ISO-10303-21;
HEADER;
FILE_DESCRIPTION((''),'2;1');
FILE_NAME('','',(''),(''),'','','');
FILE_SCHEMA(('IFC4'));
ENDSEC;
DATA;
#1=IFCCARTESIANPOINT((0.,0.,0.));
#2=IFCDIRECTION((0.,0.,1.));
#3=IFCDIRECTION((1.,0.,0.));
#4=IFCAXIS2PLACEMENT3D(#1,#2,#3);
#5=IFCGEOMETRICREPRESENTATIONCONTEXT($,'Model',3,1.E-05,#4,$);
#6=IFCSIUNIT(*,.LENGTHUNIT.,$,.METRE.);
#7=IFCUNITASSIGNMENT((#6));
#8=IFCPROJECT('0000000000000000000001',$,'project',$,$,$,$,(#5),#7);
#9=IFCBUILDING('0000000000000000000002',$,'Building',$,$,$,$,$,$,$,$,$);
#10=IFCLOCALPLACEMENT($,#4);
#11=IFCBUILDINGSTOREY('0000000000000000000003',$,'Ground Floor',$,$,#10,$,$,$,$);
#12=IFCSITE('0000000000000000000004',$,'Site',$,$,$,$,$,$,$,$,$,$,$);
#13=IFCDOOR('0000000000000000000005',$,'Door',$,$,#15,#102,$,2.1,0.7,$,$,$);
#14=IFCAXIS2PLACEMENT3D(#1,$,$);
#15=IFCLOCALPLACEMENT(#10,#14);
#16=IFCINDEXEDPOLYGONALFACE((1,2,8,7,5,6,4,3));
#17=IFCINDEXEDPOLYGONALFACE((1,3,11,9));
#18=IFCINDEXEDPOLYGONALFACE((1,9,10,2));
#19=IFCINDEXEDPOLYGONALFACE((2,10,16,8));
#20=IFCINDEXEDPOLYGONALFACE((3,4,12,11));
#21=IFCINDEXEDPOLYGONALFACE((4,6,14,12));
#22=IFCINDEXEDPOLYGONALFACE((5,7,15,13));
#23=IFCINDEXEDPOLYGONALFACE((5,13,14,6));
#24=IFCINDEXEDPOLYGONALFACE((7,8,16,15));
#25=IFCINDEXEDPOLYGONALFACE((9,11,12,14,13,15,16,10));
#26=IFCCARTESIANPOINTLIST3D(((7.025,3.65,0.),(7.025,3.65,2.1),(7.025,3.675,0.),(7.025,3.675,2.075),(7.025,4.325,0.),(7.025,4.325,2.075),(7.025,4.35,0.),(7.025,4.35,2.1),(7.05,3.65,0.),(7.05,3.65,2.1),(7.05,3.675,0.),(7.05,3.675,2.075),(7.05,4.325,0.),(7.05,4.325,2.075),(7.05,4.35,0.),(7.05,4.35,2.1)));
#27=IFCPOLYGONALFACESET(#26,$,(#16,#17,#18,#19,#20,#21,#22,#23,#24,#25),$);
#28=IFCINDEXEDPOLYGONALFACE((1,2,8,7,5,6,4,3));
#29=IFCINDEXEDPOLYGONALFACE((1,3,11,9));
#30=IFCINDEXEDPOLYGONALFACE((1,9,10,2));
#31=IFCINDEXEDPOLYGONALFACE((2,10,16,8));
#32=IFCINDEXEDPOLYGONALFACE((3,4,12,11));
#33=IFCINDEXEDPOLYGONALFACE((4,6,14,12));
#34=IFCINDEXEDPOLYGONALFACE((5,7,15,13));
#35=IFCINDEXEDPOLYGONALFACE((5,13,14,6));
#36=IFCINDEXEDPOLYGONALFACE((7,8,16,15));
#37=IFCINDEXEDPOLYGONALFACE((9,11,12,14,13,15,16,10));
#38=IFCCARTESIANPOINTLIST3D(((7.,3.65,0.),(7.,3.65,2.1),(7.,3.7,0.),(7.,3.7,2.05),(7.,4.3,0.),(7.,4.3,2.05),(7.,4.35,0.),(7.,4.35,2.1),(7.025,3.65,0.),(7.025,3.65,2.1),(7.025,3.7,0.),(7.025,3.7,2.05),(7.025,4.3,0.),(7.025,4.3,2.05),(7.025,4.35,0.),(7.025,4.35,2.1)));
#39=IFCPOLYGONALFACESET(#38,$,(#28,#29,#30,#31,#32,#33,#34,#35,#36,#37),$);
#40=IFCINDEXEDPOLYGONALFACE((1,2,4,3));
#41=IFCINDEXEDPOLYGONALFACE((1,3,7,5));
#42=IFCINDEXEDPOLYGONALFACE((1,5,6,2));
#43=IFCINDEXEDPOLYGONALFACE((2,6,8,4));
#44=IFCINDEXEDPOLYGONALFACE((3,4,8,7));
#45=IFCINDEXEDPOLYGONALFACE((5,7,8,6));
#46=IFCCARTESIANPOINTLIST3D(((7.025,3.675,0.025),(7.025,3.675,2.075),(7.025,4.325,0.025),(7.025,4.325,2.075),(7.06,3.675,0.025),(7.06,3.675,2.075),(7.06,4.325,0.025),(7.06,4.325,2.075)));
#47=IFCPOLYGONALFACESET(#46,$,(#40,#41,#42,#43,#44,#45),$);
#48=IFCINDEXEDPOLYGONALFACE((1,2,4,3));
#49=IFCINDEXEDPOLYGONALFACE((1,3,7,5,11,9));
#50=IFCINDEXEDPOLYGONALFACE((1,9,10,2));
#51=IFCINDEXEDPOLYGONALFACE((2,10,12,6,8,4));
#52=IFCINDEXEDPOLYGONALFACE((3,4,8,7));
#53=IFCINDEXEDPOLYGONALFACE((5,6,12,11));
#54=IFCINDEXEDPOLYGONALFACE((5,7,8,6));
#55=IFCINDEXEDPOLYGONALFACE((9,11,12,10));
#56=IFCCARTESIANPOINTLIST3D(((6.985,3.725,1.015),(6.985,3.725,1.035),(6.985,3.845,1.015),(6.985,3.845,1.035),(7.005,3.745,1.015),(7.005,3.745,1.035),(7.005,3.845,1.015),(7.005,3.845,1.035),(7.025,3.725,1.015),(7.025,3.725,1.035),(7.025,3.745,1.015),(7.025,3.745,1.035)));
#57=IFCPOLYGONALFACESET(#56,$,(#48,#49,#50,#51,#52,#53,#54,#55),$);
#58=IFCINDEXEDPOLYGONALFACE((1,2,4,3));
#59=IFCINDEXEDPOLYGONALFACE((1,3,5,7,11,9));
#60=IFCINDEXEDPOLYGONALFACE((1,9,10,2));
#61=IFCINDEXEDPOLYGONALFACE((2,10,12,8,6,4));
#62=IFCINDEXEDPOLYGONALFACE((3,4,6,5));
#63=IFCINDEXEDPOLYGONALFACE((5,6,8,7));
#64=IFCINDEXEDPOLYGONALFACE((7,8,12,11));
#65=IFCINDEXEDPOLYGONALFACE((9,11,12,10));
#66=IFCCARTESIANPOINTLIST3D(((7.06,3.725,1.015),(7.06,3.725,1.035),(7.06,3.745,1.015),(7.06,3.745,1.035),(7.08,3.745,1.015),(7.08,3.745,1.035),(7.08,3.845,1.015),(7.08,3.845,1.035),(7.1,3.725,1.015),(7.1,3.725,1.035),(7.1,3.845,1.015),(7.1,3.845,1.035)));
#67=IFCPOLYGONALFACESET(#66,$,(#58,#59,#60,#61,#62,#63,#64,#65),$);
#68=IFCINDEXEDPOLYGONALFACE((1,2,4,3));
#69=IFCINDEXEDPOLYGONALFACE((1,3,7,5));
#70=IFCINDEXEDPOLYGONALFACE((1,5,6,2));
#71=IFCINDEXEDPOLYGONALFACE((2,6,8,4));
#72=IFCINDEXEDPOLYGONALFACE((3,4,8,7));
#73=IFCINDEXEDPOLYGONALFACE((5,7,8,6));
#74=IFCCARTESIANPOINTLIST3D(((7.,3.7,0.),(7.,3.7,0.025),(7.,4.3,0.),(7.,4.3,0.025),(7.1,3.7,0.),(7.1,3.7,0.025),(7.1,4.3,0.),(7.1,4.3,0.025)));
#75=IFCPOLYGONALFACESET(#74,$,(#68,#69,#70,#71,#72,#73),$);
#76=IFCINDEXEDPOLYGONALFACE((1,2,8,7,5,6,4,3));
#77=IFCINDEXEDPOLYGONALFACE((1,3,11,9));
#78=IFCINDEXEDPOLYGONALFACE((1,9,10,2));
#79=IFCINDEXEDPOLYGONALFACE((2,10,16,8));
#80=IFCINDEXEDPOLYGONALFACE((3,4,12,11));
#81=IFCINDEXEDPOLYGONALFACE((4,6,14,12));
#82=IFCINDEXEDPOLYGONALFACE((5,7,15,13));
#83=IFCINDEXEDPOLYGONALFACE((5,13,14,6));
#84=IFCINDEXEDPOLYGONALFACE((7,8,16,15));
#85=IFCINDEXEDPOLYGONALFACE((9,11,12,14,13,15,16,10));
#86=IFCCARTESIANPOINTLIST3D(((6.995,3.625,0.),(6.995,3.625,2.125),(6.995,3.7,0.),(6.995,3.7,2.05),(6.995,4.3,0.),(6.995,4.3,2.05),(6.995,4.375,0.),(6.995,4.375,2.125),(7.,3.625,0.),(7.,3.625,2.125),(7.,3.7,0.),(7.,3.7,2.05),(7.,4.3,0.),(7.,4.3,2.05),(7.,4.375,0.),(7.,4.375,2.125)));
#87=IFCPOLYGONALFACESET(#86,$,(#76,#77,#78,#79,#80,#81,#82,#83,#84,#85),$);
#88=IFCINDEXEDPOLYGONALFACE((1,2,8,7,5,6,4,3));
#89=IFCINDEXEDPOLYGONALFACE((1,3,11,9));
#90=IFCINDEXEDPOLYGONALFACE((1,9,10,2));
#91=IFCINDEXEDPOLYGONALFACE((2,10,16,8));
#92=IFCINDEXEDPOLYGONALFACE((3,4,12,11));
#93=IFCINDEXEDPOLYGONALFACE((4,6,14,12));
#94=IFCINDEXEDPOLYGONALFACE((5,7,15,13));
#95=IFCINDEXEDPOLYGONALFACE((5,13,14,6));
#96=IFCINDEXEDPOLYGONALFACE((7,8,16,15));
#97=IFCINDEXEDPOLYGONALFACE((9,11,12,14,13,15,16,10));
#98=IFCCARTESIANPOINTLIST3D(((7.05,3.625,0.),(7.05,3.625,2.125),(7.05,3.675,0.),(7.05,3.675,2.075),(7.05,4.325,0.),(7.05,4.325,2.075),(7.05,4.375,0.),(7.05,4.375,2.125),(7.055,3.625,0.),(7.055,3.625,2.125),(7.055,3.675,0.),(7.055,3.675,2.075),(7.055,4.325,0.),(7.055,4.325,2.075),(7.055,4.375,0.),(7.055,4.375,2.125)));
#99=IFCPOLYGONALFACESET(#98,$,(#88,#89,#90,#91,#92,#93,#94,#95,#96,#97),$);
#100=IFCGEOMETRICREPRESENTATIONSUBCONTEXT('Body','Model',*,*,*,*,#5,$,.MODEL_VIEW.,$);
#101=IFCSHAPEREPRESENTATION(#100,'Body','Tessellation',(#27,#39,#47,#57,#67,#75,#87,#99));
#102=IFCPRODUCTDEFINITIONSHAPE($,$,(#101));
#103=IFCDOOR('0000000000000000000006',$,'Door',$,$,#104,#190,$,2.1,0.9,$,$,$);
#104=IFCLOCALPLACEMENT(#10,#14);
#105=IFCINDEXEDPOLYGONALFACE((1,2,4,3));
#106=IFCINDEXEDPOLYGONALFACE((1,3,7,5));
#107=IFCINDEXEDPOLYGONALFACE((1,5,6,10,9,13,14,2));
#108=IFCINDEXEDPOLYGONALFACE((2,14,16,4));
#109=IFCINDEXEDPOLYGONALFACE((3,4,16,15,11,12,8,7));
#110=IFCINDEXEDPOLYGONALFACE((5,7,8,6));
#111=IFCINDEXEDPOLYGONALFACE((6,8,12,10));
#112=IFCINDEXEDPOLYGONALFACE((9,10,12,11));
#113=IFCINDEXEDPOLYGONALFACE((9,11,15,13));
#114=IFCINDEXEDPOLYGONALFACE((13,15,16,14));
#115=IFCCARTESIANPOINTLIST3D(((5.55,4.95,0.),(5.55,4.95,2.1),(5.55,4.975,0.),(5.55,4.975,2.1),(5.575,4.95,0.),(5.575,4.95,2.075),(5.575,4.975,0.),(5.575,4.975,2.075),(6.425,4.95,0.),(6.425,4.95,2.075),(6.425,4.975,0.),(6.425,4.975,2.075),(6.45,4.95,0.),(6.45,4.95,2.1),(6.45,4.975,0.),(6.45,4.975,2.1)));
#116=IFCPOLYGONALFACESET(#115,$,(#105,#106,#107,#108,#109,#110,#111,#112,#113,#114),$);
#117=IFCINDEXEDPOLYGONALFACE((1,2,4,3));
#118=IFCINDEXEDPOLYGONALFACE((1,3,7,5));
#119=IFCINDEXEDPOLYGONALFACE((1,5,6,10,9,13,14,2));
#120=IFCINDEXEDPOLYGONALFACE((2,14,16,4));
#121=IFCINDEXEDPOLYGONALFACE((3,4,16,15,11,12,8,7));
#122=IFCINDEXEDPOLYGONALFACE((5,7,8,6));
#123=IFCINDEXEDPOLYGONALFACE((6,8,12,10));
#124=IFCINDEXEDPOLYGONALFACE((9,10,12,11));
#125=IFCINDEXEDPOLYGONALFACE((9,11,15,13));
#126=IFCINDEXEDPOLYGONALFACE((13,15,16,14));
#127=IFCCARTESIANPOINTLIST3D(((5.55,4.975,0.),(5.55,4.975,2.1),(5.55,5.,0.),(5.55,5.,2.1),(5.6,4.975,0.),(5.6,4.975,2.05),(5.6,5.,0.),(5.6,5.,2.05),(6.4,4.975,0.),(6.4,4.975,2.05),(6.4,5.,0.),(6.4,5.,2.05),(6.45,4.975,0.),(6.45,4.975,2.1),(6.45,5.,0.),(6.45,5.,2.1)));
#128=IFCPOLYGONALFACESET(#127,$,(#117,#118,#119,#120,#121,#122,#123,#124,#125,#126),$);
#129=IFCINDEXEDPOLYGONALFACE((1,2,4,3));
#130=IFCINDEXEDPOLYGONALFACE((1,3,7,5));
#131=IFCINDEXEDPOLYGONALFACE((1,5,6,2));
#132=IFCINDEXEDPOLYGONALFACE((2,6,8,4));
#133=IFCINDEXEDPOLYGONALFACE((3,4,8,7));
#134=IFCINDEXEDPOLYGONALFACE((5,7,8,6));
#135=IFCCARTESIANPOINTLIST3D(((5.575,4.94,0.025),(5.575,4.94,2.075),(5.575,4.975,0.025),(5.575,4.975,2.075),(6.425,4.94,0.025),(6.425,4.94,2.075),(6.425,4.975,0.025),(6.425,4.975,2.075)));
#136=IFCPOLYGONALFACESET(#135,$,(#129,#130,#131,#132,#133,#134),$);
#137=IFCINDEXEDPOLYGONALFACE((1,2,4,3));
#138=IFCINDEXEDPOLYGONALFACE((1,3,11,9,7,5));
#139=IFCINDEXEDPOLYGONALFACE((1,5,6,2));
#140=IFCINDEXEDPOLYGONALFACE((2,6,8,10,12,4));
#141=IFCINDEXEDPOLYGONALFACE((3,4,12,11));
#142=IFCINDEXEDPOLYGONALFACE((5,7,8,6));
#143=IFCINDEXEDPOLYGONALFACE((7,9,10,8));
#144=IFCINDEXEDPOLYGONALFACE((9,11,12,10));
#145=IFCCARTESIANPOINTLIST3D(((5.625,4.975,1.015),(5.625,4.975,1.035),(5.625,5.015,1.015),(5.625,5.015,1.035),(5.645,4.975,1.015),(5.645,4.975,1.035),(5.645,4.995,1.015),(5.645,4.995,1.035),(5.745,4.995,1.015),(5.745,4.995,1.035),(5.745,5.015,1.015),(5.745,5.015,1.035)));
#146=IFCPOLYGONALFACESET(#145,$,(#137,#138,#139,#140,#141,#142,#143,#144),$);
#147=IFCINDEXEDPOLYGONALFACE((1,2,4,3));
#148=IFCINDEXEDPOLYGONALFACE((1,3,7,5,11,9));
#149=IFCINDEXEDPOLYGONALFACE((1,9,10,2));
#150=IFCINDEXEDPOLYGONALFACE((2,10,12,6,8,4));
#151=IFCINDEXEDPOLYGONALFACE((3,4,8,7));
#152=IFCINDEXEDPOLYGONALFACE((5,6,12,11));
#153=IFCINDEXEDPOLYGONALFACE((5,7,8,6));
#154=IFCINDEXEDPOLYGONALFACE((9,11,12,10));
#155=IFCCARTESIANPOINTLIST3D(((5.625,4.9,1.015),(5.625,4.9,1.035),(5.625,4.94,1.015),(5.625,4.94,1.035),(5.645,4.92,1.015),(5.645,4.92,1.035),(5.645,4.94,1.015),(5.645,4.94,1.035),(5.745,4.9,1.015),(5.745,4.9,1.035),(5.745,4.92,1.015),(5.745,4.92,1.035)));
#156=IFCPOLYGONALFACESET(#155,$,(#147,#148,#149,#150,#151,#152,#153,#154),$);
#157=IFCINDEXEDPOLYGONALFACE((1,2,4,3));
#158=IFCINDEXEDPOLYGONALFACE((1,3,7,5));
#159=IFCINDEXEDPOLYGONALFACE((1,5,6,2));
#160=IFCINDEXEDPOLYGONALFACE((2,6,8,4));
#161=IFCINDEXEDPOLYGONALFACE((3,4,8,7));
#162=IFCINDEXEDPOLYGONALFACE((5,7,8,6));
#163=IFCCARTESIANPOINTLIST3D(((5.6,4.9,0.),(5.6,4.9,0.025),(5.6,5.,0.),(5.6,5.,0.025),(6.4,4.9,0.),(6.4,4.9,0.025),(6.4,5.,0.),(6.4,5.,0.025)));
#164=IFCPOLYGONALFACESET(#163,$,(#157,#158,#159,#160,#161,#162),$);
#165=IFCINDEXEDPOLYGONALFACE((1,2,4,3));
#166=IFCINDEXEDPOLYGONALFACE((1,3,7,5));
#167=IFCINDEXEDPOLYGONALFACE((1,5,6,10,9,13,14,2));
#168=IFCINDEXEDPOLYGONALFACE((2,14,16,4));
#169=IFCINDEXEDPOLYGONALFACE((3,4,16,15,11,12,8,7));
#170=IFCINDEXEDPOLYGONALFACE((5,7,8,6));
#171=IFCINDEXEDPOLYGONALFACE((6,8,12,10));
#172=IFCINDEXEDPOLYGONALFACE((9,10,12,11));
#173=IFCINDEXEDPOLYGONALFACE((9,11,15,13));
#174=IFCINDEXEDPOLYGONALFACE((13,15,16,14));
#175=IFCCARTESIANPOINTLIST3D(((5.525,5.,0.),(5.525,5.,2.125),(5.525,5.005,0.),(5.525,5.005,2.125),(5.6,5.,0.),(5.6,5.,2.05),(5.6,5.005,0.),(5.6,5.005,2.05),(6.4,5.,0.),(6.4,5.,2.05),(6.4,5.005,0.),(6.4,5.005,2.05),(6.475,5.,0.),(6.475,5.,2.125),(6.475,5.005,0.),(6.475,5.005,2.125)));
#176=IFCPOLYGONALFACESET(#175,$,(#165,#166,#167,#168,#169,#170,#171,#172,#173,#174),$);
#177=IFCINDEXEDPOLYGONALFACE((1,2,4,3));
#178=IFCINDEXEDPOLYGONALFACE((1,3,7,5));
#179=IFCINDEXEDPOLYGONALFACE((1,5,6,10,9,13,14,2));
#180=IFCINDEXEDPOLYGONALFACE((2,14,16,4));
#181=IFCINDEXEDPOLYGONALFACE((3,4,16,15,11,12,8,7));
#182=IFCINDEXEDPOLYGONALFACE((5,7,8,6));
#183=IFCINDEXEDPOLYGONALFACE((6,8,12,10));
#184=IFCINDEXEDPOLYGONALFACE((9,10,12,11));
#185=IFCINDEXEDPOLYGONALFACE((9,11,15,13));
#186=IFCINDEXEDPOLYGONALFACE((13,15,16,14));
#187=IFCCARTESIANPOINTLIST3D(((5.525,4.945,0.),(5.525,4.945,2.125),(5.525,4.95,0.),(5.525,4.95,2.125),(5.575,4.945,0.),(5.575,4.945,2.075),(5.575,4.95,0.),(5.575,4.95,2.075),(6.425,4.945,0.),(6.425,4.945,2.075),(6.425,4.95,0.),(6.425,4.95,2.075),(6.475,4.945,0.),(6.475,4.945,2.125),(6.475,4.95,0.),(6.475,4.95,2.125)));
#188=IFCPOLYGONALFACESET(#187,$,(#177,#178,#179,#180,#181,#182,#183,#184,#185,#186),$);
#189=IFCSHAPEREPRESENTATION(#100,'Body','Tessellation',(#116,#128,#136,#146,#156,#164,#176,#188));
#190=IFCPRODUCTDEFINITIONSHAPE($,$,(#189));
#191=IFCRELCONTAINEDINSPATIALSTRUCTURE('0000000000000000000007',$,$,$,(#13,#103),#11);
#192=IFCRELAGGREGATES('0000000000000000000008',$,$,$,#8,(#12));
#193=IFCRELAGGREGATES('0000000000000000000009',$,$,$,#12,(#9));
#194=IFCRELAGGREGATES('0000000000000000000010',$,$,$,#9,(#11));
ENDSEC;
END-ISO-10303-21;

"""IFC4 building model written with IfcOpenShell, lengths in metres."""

from ifc_helpers import new_model, si_unit, frame, origin_with_axes, place, context, subcontext, project, spatial, line, indexed_curve, outline, extrude, element, save


model = new_model("IFC4")

# Units and contexts
model_context = context("Model", 3, precision=1e-05, world=origin_with_axes())
body_context = subcontext(model_context, "Body", "Model", "MODEL_VIEW")
ifc_project = project(units=[si_unit("LENGTHUNIT", "METRE")], contexts=[model_context])

# Site, building, storey
site = spatial("IfcSite", under=ifc_project, Name="Site")
building = spatial("IfcBuilding", under=site, Name="Building")
storey_placement = place(None, origin_with_axes())
storey = spatial("IfcBuildingStorey", under=building, at=storey_placement, Name="Ground Floor")

# Doors
door_1_placement = place(storey_placement, frame((7.0, 4.35, 0.0), z_axis=(0.0, 0.0, 1.0), x_axis=(0.0, -1.0, 0.0)))
element("IfcDoor", 1, at=door_1_placement, inside=storey, Name="Door", OverallHeight=2.1, OverallWidth=0.7, context=body_context, shape_type="SweptSolid", body=[
    extrude(outline(indexed_curve([(0.0, 0.0), (0.0, 2.1), (0.7, 2.1), (0.7, 0.0), (0.675, 0.0), (0.675, 2.075), (0.025, 2.075), (0.025, 0.0)], segments=[line(1, 2, 3, 4, 5, 6, 7, 8, 1)])), frame((0.0, 0.025, 0.0), z_axis=(0.0, -1.0, 0.0), x_axis=(1.0, 0.0, 0.0)), (0.0, 0.0, -1.0), 0.025),
    extrude(outline(indexed_curve([(0.0, 0.0), (0.0, 2.1), (0.7, 2.1), (0.7, 0.0), (0.65, 0.0), (0.65, 2.05), (0.05, 2.05), (0.05, 0.0)], segments=[line(1, 2, 3, 4, 5, 6, 7, 8, 1)])), frame((0.0, 0.0, 0.0), z_axis=(0.0, -1.0, 0.0), x_axis=(1.0, 0.0, 0.0)), (0.0, 0.0, -1.0), 0.025),
    extrude(outline(indexed_curve([(0.0, 0.0), (0.65, 0.0), (0.65, 0.035), (0.0, 0.035)], segments=[line(1, 2, 3, 4, 1)])), frame((0.025, 0.025, 0.025), z_axis=(0.0, 0.0, 1.0), x_axis=(1.0, 0.0, 0.0)), (0.0, 0.0, 1.0), 2.05),
    extrude(outline(indexed_curve([(0.0, 0.0), (0.0, -0.04), (-0.12, -0.04), (-0.12, -0.02), (-0.02, -0.02), (-0.02, 0.0)], segments=[line(1, 2, 3, 4, 5, 6, 1)])), frame((0.625, 0.025, 1.015), z_axis=(0.0, 0.0, 1.0), x_axis=(1.0, 0.0, 0.0)), (0.0, 0.0, 1.0), 0.02),
    extrude(outline(indexed_curve([(0.0, 0.0), (0.0, 0.04), (-0.12, 0.04), (-0.12, 0.02), (-0.02, 0.02), (-0.02, 0.0)], segments=[line(1, 2, 3, 4, 5, 6, 1)])), frame((0.625, 0.06, 1.015), z_axis=(0.0, 0.0, 1.0), x_axis=(1.0, 0.0, 0.0)), (0.0, 0.0, 1.0), 0.02),
    extrude(outline(indexed_curve([(0.0, 0.0), (0.6, 0.0), (0.6, 0.1), (0.0, 0.1)], segments=[line(1, 2, 3, 4, 1)])), frame((0.05, 0.0, 0.0), z_axis=(0.0, 0.0, 1.0), x_axis=(1.0, 0.0, 0.0)), (0.0, 0.0, 1.0), 0.025),
    extrude(outline(indexed_curve([(0.0, 0.0), (0.0, 2.125), (0.75, 2.125), (0.75, 0.0), (0.675, 0.0), (0.675, 2.05), (0.075, 2.05), (0.075, 0.0)], segments=[line(1, 2, 3, 4, 5, 6, 7, 8, 1)])), frame((-0.025, -0.005, 0.0), z_axis=(0.0, -1.0, 0.0), x_axis=(1.0, 0.0, 0.0)), (0.0, 0.0, -1.0), 0.005),
    extrude(outline(indexed_curve([(0.0, 0.0), (0.0, 2.125), (0.75, 2.125), (0.75, 0.0), (0.7, 0.0), (0.7, 2.075), (0.05, 2.075), (0.05, 0.0)], segments=[line(1, 2, 3, 4, 5, 6, 7, 8, 1)])), frame((-0.025, 0.05, 0.0), z_axis=(0.0, -1.0, 0.0), x_axis=(1.0, 0.0, 0.0)), (0.0, 0.0, -1.0), 0.005),
])
door_2_placement = place(storey_placement, frame((6.45, 5.0, 0.0), z_axis=(0.0, 0.0, 1.0), x_axis=(-1.0, 0.0, 0.0)))
element("IfcDoor", 2, at=door_2_placement, inside=storey, Name="Door", OverallHeight=2.1, OverallWidth=0.9, context=body_context, shape_type="SweptSolid", body=[
    extrude(outline(indexed_curve([(0.0, 0.0), (0.0, 2.1), (0.9, 2.1), (0.9, 0.0), (0.875, 0.0), (0.875, 2.075), (0.025, 2.075), (0.025, 0.0)], segments=[line(1, 2, 3, 4, 5, 6, 7, 8, 1)])), frame((0.0, 0.025, 0.0), z_axis=(0.0, -1.0, 0.0), x_axis=(1.0, 0.0, 0.0)), (0.0, 0.0, -1.0), 0.025),
    extrude(outline(indexed_curve([(0.0, 0.0), (0.0, 2.1), (0.9, 2.1), (0.9, 0.0), (0.85, 0.0), (0.85, 2.05), (0.05, 2.05), (0.05, 0.0)], segments=[line(1, 2, 3, 4, 5, 6, 7, 8, 1)])), frame((0.0, 0.0, 0.0), z_axis=(0.0, -1.0, 0.0), x_axis=(1.0, 0.0, 0.0)), (0.0, 0.0, -1.0), 0.025),
    extrude(outline(indexed_curve([(0.0, 0.0), (0.85, 0.0), (0.85, 0.035), (0.0, 0.035)], segments=[line(1, 2, 3, 4, 1)])), frame((0.025, 0.025, 0.025), z_axis=(0.0, 0.0, 1.0), x_axis=(1.0, 0.0, 0.0)), (0.0, 0.0, 1.0), 2.05),
    extrude(outline(indexed_curve([(0.0, 0.0), (0.0, -0.04), (-0.12, -0.04), (-0.12, -0.02), (-0.02, -0.02), (-0.02, 0.0)], segments=[line(1, 2, 3, 4, 5, 6, 1)])), frame((0.825, 0.025, 1.015), z_axis=(0.0, 0.0, 1.0), x_axis=(1.0, 0.0, 0.0)), (0.0, 0.0, 1.0), 0.02),
    extrude(outline(indexed_curve([(0.0, 0.0), (0.0, 0.04), (-0.12, 0.04), (-0.12, 0.02), (-0.02, 0.02), (-0.02, 0.0)], segments=[line(1, 2, 3, 4, 5, 6, 1)])), frame((0.825, 0.06, 1.015), z_axis=(0.0, 0.0, 1.0), x_axis=(1.0, 0.0, 0.0)), (0.0, 0.0, 1.0), 0.02),
    extrude(outline(indexed_curve([(0.0, 0.0), (0.8, 0.0), (0.8, 0.1), (0.0, 0.1)], segments=[line(1, 2, 3, 4, 1)])), frame((0.05, 0.0, 0.0), z_axis=(0.0, 0.0, 1.0), x_axis=(1.0, 0.0, 0.0)), (0.0, 0.0, 1.0), 0.025),
    extrude(outline(indexed_curve([(0.0, 0.0), (0.0, 2.125), (0.95, 2.125), (0.95, 0.0), (0.875, 0.0), (0.875, 2.05), (0.075, 2.05), (0.075, 0.0)], segments=[line(1, 2, 3, 4, 5, 6, 7, 8, 1)])), frame((-0.025, -0.005, 0.0), z_axis=(0.0, -1.0, 0.0), x_axis=(1.0, 0.0, 0.0)), (0.0, 0.0, -1.0), 0.005),
    extrude(outline(indexed_curve([(0.0, 0.0), (0.0, 2.125), (0.95, 2.125), (0.95, 0.0), (0.9, 0.0), (0.9, 2.075), (0.05, 2.075), (0.05, 0.0)], segments=[line(1, 2, 3, 4, 5, 6, 7, 8, 1)])), frame((-0.025, 0.05, 0.0), z_axis=(0.0, -1.0, 0.0), x_axis=(1.0, 0.0, 0.0)), (0.0, 0.0, -1.0), 0.005),
])

save(model, "model.ifc")
